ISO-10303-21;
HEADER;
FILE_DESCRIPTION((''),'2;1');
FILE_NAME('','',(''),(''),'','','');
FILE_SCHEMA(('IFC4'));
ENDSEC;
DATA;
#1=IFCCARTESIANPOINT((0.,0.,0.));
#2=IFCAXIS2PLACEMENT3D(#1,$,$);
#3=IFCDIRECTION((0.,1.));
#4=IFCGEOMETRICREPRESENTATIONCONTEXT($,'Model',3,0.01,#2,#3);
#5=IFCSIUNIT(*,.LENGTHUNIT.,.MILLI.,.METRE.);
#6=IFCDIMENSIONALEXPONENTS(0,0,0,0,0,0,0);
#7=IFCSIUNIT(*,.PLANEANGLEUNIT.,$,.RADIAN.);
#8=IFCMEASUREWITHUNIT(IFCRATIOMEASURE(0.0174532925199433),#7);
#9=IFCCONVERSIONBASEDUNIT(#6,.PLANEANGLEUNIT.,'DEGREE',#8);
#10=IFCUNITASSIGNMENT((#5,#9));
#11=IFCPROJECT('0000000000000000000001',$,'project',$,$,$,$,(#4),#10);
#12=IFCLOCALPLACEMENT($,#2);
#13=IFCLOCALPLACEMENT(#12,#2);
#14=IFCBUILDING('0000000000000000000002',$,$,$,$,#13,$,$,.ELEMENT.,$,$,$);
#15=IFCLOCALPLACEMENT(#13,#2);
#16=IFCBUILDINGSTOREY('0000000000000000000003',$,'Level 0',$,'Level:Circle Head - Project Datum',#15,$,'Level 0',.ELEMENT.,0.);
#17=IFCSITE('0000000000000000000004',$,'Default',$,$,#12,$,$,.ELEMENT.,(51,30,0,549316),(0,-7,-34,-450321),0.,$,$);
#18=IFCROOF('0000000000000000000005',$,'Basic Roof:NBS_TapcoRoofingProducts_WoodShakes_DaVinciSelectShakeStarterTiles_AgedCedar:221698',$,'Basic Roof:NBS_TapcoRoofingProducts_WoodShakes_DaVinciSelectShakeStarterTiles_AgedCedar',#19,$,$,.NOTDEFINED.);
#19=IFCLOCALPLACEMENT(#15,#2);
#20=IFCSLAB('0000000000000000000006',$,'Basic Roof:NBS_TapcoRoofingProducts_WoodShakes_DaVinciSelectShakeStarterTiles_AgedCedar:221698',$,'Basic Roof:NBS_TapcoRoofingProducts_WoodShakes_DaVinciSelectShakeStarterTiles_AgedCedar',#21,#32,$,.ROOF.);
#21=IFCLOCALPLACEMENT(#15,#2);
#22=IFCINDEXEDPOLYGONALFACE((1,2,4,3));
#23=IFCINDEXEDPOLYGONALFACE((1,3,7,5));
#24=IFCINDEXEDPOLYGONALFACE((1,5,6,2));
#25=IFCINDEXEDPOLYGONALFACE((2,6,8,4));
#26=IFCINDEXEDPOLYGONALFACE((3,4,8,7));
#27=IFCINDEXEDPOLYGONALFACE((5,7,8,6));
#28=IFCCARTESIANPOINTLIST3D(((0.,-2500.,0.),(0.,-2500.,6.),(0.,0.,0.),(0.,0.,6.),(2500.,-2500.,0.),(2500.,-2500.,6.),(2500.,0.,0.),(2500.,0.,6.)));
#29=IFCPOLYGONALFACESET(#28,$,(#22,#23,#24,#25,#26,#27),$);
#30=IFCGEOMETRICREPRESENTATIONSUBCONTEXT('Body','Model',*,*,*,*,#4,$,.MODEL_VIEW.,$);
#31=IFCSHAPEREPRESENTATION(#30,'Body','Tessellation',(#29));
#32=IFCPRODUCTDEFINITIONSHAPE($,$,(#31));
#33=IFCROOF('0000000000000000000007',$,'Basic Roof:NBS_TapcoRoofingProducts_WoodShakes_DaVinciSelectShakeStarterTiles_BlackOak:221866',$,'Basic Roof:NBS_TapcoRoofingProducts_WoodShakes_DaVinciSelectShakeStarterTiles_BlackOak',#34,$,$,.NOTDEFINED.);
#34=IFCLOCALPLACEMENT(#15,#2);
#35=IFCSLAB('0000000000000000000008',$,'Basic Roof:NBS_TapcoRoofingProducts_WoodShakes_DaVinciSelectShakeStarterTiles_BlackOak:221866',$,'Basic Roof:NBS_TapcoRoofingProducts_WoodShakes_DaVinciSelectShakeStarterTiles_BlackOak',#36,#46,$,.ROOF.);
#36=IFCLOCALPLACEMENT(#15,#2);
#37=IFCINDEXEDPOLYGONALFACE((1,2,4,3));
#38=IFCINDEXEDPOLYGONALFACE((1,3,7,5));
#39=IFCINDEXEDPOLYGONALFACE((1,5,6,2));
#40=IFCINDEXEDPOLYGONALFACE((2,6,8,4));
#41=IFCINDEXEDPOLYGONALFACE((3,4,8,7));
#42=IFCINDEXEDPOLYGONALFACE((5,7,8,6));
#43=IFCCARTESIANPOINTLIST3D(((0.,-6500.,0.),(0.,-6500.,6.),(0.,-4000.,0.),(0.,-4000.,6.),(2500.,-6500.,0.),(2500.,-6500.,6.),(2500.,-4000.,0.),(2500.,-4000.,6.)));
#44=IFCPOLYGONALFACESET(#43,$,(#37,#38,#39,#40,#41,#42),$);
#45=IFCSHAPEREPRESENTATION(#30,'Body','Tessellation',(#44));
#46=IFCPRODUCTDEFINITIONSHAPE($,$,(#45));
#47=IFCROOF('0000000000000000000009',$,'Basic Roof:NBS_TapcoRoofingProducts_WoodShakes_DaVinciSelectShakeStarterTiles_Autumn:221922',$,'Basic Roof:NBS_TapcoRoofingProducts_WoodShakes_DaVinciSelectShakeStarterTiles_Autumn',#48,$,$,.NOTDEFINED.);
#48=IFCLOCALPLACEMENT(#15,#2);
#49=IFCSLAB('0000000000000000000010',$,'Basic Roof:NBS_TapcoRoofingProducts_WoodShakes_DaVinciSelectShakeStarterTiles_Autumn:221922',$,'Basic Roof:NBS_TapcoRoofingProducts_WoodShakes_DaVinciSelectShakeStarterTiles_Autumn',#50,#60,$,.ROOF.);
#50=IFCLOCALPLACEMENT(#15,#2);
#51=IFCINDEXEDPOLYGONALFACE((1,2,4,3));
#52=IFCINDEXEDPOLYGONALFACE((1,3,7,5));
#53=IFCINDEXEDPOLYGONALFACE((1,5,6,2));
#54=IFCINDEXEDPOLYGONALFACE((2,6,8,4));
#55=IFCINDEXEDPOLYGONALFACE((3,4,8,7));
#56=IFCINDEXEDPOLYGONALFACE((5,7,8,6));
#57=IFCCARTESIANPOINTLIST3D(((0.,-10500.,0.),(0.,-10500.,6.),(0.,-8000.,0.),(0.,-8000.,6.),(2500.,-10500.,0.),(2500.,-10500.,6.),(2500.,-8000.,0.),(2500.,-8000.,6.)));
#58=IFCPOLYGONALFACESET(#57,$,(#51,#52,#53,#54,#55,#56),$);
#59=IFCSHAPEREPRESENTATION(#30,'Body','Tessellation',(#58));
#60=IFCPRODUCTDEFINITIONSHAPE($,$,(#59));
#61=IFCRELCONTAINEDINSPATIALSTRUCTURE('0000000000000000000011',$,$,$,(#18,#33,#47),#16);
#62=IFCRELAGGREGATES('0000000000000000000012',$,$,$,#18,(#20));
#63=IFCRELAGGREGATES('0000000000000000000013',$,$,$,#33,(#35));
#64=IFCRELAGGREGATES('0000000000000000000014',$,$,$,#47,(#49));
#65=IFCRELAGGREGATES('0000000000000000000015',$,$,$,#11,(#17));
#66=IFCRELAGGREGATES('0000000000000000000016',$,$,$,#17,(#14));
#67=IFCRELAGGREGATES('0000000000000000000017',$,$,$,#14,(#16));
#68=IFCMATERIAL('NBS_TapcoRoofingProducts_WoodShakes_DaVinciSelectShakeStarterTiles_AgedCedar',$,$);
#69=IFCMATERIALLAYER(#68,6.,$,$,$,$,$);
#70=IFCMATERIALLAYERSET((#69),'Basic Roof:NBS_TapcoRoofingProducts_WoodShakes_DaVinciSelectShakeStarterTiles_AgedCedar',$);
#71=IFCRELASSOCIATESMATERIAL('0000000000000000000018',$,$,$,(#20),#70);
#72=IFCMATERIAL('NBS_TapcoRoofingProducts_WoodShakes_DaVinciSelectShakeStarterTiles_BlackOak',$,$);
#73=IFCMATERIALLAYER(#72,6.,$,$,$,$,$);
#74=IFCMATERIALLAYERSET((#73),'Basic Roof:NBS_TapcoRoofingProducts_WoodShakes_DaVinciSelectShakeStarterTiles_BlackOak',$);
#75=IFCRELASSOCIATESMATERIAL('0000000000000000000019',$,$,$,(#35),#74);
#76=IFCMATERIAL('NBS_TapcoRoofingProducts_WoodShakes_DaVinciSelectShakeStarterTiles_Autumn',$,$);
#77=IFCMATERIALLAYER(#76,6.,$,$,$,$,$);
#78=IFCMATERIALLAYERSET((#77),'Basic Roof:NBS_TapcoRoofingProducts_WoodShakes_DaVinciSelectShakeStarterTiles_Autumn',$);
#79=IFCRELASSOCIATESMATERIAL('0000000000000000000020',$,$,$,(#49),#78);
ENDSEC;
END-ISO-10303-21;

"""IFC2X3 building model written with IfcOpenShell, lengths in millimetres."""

from ifc_helpers import new_model, entity, si_unit, converted_unit, direction, frame, frame_2d, origin, place, context, subcontext, project, spatial, rectangle, extrude, material, layer, layer_set, element, aggregate, save


model = new_model("IFC2X3")

# Units and contexts
model_context = context("Model", 3, precision=0.01, world=origin(), true_north=direction((0.0, 1.0)))
body_context = subcontext(model_context, "Body", "Model", "MODEL_VIEW")
ifc_project = project(units=[si_unit("LENGTHUNIT", "METRE", prefix="MILLI"), converted_unit("PLANEANGLEUNIT", "DEGREE", entity("IfcRatioMeasure", 0.0174532925199433), si_unit("PLANEANGLEUNIT", "RADIAN"), dimensions=[0, 0, 0, 0, 0, 0, 0])], contexts=[model_context])

# Site, building, storey
site_placement = place(None, origin())
site = spatial("IfcSite", under=ifc_project, at=site_placement, Name="Default", CompositionType="ELEMENT", RefLatitude=(51, 30, 0, 549316), RefLongitude=(0, -7, -34, -450321), RefElevation=0.0)
building_placement = place(site_placement, origin())
building = spatial("IfcBuilding", under=site, at=building_placement, CompositionType="ELEMENT")
storey_placement = place(building_placement, origin())
storey = spatial("IfcBuildingStorey", under=building, at=storey_placement, Name="Level 0", ObjectType="Level:Circle Head - Project Datum", LongName="Level 0", CompositionType="ELEMENT", Elevation=0.0)

# Roofs, slabs
roof_1_placement = place(storey_placement, origin())
roof_1 = element("IfcRoof", 1, at=roof_1_placement, inside=storey, Name="Basic Roof:NBS_TapcoRoofingProducts_WoodShakes_DaVinciSelectShakeStarterTiles_AgedCedar:221698", ObjectType="Basic Roof:NBS_TapcoRoofingProducts_WoodShakes_DaVinciSelectShakeStarterTiles_AgedCedar", ShapeType="NOTDEFINED")
ifc_material_1 = material(Name="NBS_TapcoRoofingProducts_WoodShakes_DaVinciSelectShakeStarterTiles_AgedCedar")
ifc_layer_1 = layer(ifc_material_1, 6.0)
ifc_layer_set_1 = layer_set([ifc_layer_1], Name="Basic Roof:NBS_TapcoRoofingProducts_WoodShakes_DaVinciSelectShakeStarterTiles_AgedCedar")
slab_1_placement = place(storey_placement, origin())
slab_1 = element("IfcSlab", 2, at=slab_1_placement, material=ifc_layer_set_1, Name="Basic Roof:NBS_TapcoRoofingProducts_WoodShakes_DaVinciSelectShakeStarterTiles_AgedCedar:221698", ObjectType="Basic Roof:NBS_TapcoRoofingProducts_WoodShakes_DaVinciSelectShakeStarterTiles_AgedCedar", PredefinedType="ROOF", context=body_context, shape_type="SweptSolid", body=[
    extrude(rectangle(XDim=2500.0, YDim=2500.0, at=frame_2d((0.0, 0.0), x_axis=(0.0, 1.0))), frame((1250.0, -1250.0, 0.0)), (0.0, 0.0, 1.0), 6.0),
])
aggregate(roof_1, [slab_1])
roof_2_placement = place(storey_placement, frame((0.0, -6500.0, 0.0)))
roof_2 = element("IfcRoof", 3, at=roof_2_placement, inside=storey, Name="Basic Roof:NBS_TapcoRoofingProducts_WoodShakes_DaVinciSelectShakeStarterTiles_BlackOak:221866", ObjectType="Basic Roof:NBS_TapcoRoofingProducts_WoodShakes_DaVinciSelectShakeStarterTiles_BlackOak", ShapeType="NOTDEFINED")
ifc_material_2 = material(Name="NBS_TapcoRoofingProducts_WoodShakes_DaVinciSelectShakeStarterTiles_BlackOak")
ifc_layer_2 = layer(ifc_material_2, 6.0)
ifc_layer_set_2 = layer_set([ifc_layer_2], Name="Basic Roof:NBS_TapcoRoofingProducts_WoodShakes_DaVinciSelectShakeStarterTiles_BlackOak")
slab_2_placement = place(roof_2_placement, origin())
slab_2 = element("IfcSlab", 4, at=slab_2_placement, material=ifc_layer_set_2, Name="Basic Roof:NBS_TapcoRoofingProducts_WoodShakes_DaVinciSelectShakeStarterTiles_BlackOak:221866", ObjectType="Basic Roof:NBS_TapcoRoofingProducts_WoodShakes_DaVinciSelectShakeStarterTiles_BlackOak", PredefinedType="ROOF", context=body_context, shape_type="SweptSolid", body=[
    extrude(rectangle(XDim=2500.0, YDim=2500.0, at=frame_2d((0.0, 0.0), x_axis=(0.0, 1.0))), frame((1250.0, 1250.0, 0.0)), (0.0, 0.0, 1.0), 6.0),
])
aggregate(roof_2, [slab_2])
roof_3_placement = place(storey_placement, frame((0.0, -10500.0, 0.0)))
roof_3 = element("IfcRoof", 5, at=roof_3_placement, inside=storey, Name="Basic Roof:NBS_TapcoRoofingProducts_WoodShakes_DaVinciSelectShakeStarterTiles_Autumn:221922", ObjectType="Basic Roof:NBS_TapcoRoofingProducts_WoodShakes_DaVinciSelectShakeStarterTiles_Autumn", ShapeType="NOTDEFINED")
ifc_material_3 = material(Name="NBS_TapcoRoofingProducts_WoodShakes_DaVinciSelectShakeStarterTiles_Autumn")
ifc_layer_3 = layer(ifc_material_3, 6.0)
ifc_layer_set_3 = layer_set([ifc_layer_3], Name="Basic Roof:NBS_TapcoRoofingProducts_WoodShakes_DaVinciSelectShakeStarterTiles_Autumn")
slab_3_placement = place(roof_3_placement, origin())
slab_3 = element("IfcSlab", 6, at=slab_3_placement, material=ifc_layer_set_3, Name="Basic Roof:NBS_TapcoRoofingProducts_WoodShakes_DaVinciSelectShakeStarterTiles_Autumn:221922", ObjectType="Basic Roof:NBS_TapcoRoofingProducts_WoodShakes_DaVinciSelectShakeStarterTiles_Autumn", PredefinedType="ROOF", context=body_context, shape_type="SweptSolid", body=[
    extrude(rectangle(XDim=2500.0, YDim=2500.0, at=frame_2d((0.0, 0.0), x_axis=(0.0, 1.0))), frame((1250.0, 1250.0, 0.0)), (0.0, 0.0, 1.0), 6.0),
])
aggregate(roof_3, [slab_3])

save(model, "model.ifc")
